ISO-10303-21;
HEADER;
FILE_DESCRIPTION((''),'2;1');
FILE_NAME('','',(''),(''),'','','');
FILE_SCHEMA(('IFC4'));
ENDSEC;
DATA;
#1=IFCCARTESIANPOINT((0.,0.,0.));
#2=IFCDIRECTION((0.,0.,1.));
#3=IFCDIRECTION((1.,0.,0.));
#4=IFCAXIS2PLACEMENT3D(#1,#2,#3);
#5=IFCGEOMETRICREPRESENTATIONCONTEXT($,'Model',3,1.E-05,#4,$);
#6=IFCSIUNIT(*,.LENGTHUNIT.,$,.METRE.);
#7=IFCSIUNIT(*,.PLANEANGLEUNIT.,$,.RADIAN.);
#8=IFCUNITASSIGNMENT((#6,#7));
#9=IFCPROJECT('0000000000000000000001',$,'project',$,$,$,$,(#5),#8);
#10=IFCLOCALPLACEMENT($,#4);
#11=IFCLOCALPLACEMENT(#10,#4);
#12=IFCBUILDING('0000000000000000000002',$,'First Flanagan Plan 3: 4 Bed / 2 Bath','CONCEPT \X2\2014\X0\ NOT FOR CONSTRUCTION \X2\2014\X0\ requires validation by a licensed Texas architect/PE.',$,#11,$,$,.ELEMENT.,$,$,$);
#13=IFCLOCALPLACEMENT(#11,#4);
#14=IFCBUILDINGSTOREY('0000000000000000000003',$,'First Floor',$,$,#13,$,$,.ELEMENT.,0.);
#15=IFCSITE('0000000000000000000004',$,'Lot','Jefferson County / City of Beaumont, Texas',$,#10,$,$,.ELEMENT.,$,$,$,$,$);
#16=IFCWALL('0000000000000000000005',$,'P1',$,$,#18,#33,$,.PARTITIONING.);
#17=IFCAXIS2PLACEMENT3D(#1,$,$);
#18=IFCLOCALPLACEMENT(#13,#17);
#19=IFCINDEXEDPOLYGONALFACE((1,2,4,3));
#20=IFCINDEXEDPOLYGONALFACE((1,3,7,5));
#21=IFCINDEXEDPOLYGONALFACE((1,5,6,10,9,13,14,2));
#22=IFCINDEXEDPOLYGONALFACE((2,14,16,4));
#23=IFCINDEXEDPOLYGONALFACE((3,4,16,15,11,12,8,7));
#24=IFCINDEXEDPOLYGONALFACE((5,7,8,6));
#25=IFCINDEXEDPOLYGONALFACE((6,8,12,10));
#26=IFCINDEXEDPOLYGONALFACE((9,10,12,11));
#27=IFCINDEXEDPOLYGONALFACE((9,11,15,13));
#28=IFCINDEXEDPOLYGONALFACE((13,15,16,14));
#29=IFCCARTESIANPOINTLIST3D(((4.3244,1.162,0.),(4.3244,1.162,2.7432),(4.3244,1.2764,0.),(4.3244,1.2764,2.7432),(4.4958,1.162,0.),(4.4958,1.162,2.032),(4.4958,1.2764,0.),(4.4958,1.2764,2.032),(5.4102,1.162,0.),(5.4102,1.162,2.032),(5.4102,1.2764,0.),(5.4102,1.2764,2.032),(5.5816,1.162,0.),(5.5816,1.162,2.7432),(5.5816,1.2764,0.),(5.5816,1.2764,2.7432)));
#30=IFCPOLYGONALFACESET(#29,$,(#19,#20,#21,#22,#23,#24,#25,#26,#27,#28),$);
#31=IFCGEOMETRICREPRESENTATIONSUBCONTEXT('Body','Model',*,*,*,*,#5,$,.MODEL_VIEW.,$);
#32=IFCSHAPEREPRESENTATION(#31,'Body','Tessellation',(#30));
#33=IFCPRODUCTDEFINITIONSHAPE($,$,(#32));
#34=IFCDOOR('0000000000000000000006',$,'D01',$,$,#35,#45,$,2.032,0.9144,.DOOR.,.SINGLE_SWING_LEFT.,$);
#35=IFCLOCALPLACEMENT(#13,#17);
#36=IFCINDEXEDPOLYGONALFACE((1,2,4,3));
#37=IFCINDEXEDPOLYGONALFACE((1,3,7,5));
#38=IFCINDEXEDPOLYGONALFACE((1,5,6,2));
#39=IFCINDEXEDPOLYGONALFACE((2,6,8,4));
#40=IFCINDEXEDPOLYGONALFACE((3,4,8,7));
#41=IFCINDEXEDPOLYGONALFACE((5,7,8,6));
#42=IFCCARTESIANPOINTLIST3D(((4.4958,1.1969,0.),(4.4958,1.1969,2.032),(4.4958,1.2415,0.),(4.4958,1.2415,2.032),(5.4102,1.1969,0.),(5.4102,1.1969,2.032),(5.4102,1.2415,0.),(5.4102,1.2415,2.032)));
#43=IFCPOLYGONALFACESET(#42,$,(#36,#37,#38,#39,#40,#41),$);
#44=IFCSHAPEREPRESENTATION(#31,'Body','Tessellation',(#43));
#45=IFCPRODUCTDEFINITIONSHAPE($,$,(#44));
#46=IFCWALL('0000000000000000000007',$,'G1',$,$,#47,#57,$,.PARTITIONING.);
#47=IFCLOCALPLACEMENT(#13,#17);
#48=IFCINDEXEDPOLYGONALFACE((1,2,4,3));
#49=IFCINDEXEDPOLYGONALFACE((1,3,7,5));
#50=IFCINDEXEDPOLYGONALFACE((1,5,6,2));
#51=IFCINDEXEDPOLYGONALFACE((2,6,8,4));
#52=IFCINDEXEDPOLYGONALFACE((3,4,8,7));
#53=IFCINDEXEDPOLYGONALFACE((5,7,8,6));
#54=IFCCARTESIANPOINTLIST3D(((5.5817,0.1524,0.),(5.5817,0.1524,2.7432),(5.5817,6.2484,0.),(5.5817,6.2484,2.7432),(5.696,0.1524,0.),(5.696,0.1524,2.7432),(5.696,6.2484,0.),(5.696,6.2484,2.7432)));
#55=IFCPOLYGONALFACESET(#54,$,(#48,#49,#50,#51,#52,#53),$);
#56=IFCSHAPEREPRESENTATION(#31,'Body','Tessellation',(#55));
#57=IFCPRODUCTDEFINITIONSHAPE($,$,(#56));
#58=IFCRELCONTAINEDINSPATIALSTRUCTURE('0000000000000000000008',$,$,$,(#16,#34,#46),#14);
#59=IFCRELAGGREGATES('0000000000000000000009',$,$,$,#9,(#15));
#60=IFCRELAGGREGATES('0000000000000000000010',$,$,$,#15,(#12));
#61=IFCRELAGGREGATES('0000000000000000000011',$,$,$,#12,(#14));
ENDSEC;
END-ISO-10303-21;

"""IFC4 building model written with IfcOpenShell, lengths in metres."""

from ifc_helpers import new_model, si_unit, frame, frame_2d, origin_with_axes, place, context, subcontext, project, spatial, rectangle, extrude, element, fill, save


model = new_model("IFC4")

# Units and contexts
model_context = context("Model", 3, precision=1e-05, world=origin_with_axes())
body_context = subcontext(model_context, "Body", "Model", "MODEL_VIEW")
ifc_project = project(units=[si_unit("LENGTHUNIT", "METRE"), si_unit("PLANEANGLEUNIT", "RADIAN")], contexts=[model_context])

# Site, building, storey
site_placement = place(None, origin_with_axes())
site = spatial("IfcSite", under=ifc_project, at=site_placement, Name="Lot", Description="Jefferson County / City of Beaumont, Texas", CompositionType="ELEMENT")
building_placement = place(site_placement, origin_with_axes())
building = spatial("IfcBuilding", under=site, at=building_placement, Name="First Flanagan Plan 3: 4 Bed / 2 Bath", Description="CONCEPT — NOT FOR CONSTRUCTION — requires validation by a licensed Texas architect/PE.", CompositionType="ELEMENT")
storey_placement = place(building_placement, origin_with_axes())
storey = spatial("IfcBuildingStorey", under=building, at=storey_placement, Name="First Floor", CompositionType="ELEMENT", Elevation=0.0)

# Wall, opening, door
wall_1_placement = place(storey_placement, frame((4.3243, 1.2192, 0.0), z_axis=(0.0, 0.0, 1.0), x_axis=(1.0, 0.0, 0.0)))
wall_1 = element("IfcWall", 1, at=wall_1_placement, inside=storey, Name="P1", PredefinedType="PARTITIONING", context=body_context, shape_type="SweptSolid", body=[
    extrude(rectangle(XDim=1.2573, YDim=0.1143, at=frame_2d((0.6287, 0.0), x_axis=(1.0, 0.0))), origin_with_axes(), (0.0, 0.0, 1.0), 2.7432),
])
opening_1_placement = place(wall_1_placement, frame((0.1715, 0.0, 0.0), z_axis=(0.0, 0.0, 1.0), x_axis=(1.0, 0.0, 0.0)))
opening_1 = element("IfcOpeningElement", 2, at=opening_1_placement, cuts=wall_1, PredefinedType="OPENING", context=body_context, shape_type="SweptSolid", body=[
    extrude(rectangle(XDim=0.9144, YDim=0.1448, at=frame_2d((0.4572, 0.0), x_axis=(1.0, 0.0))), origin_with_axes(), (0.0, 0.0, 1.0), 2.032),
])
door_1_placement = place(opening_1_placement, origin_with_axes())
door_1 = element("IfcDoor", 3, at=door_1_placement, inside=storey, Name="D01", OperationType="SINGLE_SWING_LEFT", OverallHeight=2.032, OverallWidth=0.9144, PredefinedType="DOOR", context=body_context, shape_type="SweptSolid", body=[
    extrude(rectangle(XDim=0.9144, YDim=0.0445, at=frame_2d((0.4572, 0.0), x_axis=(1.0, 0.0))), origin_with_axes(), (0.0, 0.0, 1.0), 2.032),
])
fill(opening_1, door_1)

# Wall
wall_2_placement = place(storey_placement, frame((5.6388, 0.1524, 0.0), z_axis=(0.0, 0.0, 1.0), x_axis=(0.0, 1.0, 0.0)))
element("IfcWall", 4, at=wall_2_placement, inside=storey, Name="G1", PredefinedType="PARTITIONING", context=body_context, shape_type="SweptSolid", body=[
    extrude(rectangle(XDim=6.096, YDim=0.1143, at=frame_2d((3.048, 0.0), x_axis=(1.0, 0.0))), origin_with_axes(), (0.0, 0.0, 1.0), 2.7432),
])

save(model, "model.ifc")
